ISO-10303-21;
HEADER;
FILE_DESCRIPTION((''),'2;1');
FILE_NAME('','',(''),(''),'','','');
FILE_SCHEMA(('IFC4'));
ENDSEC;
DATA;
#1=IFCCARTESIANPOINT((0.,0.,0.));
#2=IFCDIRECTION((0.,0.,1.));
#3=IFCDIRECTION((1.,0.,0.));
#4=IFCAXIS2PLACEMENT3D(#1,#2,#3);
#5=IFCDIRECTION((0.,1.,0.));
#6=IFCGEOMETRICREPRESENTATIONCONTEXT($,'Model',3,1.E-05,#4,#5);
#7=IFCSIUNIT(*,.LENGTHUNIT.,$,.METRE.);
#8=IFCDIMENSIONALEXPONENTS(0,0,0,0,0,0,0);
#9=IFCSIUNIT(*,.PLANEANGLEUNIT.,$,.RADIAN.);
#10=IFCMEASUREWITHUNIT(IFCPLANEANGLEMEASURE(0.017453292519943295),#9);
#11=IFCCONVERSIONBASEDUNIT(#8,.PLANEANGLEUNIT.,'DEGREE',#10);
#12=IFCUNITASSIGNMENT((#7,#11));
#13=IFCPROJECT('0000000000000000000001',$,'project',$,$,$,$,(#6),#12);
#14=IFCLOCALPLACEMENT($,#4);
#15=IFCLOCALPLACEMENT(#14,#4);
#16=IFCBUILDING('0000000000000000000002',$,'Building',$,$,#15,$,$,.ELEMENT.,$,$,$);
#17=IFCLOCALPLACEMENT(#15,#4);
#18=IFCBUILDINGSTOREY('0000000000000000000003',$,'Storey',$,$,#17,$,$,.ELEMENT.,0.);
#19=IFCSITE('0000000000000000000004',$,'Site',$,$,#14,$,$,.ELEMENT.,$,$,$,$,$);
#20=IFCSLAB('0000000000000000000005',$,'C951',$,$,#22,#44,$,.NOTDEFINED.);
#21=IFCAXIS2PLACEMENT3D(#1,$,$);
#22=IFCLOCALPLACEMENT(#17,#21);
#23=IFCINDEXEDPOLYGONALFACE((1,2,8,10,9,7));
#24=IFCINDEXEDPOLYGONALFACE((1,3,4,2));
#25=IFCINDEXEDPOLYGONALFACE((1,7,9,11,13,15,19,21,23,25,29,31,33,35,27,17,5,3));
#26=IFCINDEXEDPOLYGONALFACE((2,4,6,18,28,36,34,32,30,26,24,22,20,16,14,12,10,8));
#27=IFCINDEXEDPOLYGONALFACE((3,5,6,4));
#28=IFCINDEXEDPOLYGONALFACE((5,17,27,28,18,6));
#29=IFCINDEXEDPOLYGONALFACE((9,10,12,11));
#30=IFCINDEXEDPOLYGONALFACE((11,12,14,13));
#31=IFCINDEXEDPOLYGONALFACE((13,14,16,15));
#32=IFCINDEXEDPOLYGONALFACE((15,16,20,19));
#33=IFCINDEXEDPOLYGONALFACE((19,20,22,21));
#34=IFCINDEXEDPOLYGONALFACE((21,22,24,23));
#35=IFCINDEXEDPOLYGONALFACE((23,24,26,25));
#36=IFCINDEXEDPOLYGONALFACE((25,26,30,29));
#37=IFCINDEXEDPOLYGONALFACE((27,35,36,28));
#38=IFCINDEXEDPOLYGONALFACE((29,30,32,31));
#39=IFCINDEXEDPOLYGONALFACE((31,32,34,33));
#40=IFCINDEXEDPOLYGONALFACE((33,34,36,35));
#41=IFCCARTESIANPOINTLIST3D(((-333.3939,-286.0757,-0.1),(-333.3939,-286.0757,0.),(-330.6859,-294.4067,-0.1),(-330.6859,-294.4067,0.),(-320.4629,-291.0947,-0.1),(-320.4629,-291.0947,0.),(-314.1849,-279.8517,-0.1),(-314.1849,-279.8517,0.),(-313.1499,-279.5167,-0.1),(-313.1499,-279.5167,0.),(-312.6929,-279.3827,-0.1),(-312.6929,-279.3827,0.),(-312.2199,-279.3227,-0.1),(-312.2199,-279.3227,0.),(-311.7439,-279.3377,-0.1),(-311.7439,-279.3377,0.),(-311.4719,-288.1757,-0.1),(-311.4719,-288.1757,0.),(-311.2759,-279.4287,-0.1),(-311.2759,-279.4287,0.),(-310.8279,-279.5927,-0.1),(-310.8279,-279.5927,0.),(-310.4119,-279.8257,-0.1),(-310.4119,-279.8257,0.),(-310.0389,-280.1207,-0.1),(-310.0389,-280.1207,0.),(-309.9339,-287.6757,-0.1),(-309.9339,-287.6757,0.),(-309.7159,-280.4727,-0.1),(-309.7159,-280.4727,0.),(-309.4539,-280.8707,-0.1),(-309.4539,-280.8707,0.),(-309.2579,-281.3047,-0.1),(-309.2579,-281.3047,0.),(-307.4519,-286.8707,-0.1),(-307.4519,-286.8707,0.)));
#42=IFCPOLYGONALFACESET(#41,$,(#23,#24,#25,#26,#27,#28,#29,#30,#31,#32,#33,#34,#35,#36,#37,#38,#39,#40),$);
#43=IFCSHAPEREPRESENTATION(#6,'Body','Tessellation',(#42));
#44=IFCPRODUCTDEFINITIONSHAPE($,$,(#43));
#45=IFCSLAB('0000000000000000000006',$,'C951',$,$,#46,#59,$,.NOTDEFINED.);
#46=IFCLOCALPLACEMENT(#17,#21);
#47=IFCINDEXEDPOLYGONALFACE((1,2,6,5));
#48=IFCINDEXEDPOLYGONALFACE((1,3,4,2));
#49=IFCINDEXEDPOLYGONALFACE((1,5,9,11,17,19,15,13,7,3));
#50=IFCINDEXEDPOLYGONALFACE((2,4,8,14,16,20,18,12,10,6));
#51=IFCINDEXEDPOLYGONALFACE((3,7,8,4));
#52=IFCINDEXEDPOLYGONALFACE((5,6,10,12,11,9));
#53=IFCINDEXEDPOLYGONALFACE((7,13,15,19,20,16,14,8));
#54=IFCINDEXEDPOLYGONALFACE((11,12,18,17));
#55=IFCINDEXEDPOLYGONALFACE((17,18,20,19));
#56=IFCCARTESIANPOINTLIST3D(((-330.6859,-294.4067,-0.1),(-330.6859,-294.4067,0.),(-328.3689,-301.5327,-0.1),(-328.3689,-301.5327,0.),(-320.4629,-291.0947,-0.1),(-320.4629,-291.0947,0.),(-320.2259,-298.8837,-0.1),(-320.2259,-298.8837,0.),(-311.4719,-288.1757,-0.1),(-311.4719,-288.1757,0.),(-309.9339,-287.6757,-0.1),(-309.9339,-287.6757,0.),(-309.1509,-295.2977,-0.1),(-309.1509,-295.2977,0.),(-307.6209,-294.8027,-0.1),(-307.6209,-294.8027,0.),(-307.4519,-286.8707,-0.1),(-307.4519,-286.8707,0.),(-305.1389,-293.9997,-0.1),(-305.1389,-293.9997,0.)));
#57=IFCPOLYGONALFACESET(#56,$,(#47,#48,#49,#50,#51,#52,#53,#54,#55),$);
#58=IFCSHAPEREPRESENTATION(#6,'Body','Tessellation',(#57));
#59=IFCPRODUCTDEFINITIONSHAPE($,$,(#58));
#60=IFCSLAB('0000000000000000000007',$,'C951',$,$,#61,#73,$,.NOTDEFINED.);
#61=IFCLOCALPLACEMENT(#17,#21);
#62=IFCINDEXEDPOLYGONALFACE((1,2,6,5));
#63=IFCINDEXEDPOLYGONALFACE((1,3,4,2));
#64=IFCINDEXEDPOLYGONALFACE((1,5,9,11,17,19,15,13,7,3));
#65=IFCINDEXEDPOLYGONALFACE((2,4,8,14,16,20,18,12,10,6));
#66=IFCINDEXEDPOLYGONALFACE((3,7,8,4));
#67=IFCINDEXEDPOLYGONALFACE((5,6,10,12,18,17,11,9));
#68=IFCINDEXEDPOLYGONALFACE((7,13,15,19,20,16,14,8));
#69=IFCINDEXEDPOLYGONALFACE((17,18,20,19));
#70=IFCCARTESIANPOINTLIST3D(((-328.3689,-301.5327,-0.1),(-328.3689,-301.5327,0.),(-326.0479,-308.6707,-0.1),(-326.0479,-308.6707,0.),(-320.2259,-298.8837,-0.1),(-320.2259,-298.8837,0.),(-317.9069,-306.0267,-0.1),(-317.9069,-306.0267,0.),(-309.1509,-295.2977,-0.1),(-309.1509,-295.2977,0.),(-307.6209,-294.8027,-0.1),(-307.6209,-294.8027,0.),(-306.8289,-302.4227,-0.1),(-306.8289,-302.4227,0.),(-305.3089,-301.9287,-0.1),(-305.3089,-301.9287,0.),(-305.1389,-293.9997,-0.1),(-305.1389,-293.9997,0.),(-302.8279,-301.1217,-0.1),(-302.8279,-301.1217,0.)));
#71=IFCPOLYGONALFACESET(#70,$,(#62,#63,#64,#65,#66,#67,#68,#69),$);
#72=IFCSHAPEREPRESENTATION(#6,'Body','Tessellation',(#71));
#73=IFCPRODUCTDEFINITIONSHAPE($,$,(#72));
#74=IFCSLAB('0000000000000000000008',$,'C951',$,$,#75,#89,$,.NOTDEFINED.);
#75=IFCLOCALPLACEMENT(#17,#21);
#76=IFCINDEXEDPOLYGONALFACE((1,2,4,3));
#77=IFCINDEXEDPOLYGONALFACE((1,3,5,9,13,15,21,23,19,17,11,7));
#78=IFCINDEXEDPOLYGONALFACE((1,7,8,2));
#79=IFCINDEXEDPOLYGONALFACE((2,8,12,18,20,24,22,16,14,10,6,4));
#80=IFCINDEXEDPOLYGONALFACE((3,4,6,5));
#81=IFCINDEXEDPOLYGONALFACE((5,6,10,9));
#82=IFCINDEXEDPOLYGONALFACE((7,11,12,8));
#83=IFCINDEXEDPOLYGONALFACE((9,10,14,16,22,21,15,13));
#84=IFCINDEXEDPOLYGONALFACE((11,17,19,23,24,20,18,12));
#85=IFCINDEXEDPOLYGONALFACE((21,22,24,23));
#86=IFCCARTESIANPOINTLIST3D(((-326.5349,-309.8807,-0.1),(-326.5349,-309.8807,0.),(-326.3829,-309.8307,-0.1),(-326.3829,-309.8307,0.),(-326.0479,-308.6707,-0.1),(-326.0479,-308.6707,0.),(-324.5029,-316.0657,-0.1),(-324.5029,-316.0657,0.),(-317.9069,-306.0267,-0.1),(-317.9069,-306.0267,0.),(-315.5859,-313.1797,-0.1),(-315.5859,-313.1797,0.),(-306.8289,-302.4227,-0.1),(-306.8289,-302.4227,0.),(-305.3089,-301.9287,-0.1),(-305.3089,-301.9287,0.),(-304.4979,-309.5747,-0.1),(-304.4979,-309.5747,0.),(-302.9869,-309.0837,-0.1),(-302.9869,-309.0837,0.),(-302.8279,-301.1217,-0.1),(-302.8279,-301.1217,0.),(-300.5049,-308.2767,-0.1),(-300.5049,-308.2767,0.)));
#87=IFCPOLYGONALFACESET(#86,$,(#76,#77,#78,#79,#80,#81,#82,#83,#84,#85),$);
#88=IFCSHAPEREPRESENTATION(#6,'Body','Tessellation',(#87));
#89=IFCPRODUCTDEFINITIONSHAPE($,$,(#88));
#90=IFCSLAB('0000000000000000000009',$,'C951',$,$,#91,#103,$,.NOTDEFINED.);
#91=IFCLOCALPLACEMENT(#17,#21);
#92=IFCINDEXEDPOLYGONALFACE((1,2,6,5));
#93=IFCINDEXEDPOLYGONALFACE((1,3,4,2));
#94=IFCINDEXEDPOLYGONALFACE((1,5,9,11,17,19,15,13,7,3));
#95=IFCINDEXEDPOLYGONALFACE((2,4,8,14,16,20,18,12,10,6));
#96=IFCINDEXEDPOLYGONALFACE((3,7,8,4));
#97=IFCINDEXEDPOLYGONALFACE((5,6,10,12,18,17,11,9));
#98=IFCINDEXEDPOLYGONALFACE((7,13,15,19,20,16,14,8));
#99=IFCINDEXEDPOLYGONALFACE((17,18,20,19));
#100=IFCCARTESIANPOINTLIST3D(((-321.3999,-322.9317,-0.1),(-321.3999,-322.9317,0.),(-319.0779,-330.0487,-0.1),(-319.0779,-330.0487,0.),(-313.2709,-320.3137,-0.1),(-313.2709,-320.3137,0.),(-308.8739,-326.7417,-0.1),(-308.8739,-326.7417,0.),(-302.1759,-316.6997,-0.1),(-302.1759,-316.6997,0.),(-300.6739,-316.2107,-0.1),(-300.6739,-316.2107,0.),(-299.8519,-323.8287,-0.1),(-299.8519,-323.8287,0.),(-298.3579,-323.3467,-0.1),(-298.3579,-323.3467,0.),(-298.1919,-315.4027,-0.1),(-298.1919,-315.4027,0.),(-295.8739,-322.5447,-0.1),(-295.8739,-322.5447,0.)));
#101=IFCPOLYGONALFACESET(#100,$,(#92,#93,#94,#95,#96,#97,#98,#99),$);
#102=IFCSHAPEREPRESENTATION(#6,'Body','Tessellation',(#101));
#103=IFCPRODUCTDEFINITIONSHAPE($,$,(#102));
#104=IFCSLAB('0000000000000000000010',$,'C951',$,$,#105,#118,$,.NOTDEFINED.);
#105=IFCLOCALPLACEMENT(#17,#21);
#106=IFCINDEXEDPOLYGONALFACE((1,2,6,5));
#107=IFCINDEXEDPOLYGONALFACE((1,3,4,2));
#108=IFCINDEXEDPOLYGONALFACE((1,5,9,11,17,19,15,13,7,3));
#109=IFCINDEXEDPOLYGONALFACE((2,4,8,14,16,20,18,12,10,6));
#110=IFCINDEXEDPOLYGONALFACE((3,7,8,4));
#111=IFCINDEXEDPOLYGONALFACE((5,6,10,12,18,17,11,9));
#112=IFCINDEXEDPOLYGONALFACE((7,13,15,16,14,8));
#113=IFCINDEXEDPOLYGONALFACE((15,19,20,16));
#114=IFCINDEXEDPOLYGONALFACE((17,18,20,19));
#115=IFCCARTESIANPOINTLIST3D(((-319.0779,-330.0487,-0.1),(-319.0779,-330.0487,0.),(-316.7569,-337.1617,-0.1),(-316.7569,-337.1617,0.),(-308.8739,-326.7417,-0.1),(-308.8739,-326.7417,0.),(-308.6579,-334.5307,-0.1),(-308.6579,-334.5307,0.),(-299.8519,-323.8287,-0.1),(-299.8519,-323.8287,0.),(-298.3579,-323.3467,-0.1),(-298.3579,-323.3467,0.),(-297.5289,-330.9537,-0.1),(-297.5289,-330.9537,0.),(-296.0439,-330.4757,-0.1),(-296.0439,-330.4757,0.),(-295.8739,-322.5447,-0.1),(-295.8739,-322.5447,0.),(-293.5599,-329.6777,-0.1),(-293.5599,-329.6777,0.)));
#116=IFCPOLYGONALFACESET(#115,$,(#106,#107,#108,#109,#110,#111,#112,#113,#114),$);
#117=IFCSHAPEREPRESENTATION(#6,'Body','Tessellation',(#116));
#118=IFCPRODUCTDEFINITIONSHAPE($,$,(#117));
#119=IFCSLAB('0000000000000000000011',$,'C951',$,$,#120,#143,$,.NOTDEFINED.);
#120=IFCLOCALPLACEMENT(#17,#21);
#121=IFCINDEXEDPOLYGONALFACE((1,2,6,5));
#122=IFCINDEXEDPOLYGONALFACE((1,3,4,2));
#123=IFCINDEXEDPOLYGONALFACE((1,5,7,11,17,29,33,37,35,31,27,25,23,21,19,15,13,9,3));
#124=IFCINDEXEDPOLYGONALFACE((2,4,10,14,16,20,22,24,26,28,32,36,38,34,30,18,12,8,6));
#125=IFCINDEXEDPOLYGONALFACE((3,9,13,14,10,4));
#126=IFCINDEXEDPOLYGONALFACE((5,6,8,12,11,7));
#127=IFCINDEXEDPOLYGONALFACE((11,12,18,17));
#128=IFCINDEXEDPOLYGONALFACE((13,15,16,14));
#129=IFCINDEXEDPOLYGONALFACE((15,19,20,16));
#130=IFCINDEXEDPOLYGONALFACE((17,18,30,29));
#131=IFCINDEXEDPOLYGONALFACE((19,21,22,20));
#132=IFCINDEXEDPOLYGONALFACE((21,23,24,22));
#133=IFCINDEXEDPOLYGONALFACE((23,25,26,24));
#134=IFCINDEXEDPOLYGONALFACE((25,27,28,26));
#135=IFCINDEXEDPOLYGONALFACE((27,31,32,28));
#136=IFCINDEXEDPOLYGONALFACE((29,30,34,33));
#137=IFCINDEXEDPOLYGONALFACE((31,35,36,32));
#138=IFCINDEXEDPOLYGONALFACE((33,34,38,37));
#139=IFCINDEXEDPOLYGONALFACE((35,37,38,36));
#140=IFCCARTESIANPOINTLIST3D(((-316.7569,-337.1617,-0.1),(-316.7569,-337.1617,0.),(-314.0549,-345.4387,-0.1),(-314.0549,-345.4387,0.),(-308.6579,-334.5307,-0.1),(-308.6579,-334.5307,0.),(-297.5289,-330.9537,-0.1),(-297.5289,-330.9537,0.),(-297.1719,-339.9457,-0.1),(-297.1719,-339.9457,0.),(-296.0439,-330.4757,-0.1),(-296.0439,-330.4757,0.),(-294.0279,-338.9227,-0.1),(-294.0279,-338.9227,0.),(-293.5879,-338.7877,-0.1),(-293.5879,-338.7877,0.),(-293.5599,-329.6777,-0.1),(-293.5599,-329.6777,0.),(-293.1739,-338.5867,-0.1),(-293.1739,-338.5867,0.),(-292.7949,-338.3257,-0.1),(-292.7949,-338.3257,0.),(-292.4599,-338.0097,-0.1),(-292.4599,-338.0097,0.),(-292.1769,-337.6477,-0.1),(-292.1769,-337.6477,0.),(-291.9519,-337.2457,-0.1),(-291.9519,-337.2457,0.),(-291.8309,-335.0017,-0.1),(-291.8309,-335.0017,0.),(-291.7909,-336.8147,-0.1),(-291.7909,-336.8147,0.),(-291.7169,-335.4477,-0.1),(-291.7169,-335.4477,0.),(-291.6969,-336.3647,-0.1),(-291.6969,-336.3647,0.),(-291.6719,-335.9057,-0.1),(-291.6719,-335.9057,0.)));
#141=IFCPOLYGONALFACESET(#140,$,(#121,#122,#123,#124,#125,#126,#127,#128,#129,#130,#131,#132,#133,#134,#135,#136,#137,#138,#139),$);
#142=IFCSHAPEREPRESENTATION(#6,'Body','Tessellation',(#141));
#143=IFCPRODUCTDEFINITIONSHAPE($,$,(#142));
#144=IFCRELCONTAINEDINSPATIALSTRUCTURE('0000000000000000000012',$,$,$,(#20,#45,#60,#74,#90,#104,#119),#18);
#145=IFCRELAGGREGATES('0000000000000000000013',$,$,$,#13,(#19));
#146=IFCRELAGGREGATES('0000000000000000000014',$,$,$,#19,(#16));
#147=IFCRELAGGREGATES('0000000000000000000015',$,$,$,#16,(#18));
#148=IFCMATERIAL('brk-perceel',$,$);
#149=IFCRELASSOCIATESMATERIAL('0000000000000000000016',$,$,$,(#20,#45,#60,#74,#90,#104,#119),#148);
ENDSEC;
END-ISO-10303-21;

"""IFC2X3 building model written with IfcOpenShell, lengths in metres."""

from ifc_helpers import new_model, entity, si_unit, converted_unit, direction, frame, origin_with_axes, place, context, project, spatial, polyline, outline, extrude, material, element, save


model = new_model("IFC2X3")

# Units and contexts
model_context = context("Model", 3, precision=1e-05, world=origin_with_axes(), true_north=direction((0.0, 1.0, 0.0)))
ifc_project = project(units=[si_unit("LENGTHUNIT", "METRE"), converted_unit("PLANEANGLEUNIT", "DEGREE", entity("IfcPlaneAngleMeasure", 0.017453292519943295), si_unit("PLANEANGLEUNIT", "RADIAN"), dimensions=[0, 0, 0, 0, 0, 0, 0])], contexts=[model_context])

# Site, building, storey
site_placement = place(None, origin_with_axes())
site = spatial("IfcSite", under=ifc_project, at=site_placement, Name="Site", CompositionType="ELEMENT")
building_placement = place(site_placement, origin_with_axes())
building = spatial("IfcBuilding", under=site, at=building_placement, Name="Building", CompositionType="ELEMENT")
storey_placement = place(building_placement, origin_with_axes())
storey = spatial("IfcBuildingStorey", under=building, at=storey_placement, Name="Storey", CompositionType="ELEMENT", Elevation=0.0)

# Slabs
ifc_material = material(Name="brk-perceel")
slab_1_placement = place(storey_placement, frame((0.0, 0.0, -0.1), z_axis=(0.0, 0.0, 1.0), x_axis=(1.0, 0.0, 0.0)))
element("IfcSlab", 1, at=slab_1_placement, inside=storey, material=ifc_material, Name="C951", PredefinedType="NOTDEFINED", context=model_context, shape_type="SweptSolid", body=[
    extrude(outline(polyline([(-312.6929, -279.3827), (-312.2199, -279.3227), (-311.7439, -279.3377), (-311.2759, -279.4287), (-310.8279, -279.5927), (-310.4119, -279.8257), (-310.0389, -280.1207), (-309.7159, -280.4727), (-309.4539, -280.8707), (-309.2579, -281.3047), (-307.4519, -286.8707), (-309.9339, -287.6757), (-311.4719, -288.1757), (-320.4629, -291.0947), (-330.6859, -294.4067), (-333.3939, -286.0757), (-314.1849, -279.8517), (-313.1499, -279.5167), (-312.6929, -279.3827)])), origin_with_axes(), (0.0, 0.0, 1.0), 0.1),
])
slab_2_placement = place(storey_placement, frame((0.0, 0.0, -0.1), z_axis=(0.0, 0.0, 1.0), x_axis=(1.0, 0.0, 0.0)))
element("IfcSlab", 2, at=slab_2_placement, inside=storey, material=ifc_material, Name="C951", PredefinedType="NOTDEFINED", context=model_context, shape_type="SweptSolid", body=[
    extrude(outline(polyline([(-320.4629, -291.0947), (-311.4719, -288.1757), (-309.9339, -287.6757), (-307.4519, -286.8707), (-305.1389, -293.9997), (-307.6209, -294.8027), (-309.1509, -295.2977), (-320.2259, -298.8837), (-328.3689, -301.5327), (-330.6859, -294.4067), (-320.4629, -291.0947)])), origin_with_axes(), (0.0, 0.0, 1.0), 0.1),
])
slab_3_placement = place(storey_placement, frame((0.0, 0.0, -0.1), z_axis=(0.0, 0.0, 1.0), x_axis=(1.0, 0.0, 0.0)))
element("IfcSlab", 3, at=slab_3_placement, inside=storey, material=ifc_material, Name="C951", PredefinedType="NOTDEFINED", context=model_context, shape_type="SweptSolid", body=[
    extrude(outline(polyline([(-320.2259, -298.8837), (-309.1509, -295.2977), (-307.6209, -294.8027), (-305.1389, -293.9997), (-302.8279, -301.1217), (-305.3089, -301.9287), (-306.8289, -302.4227), (-317.9069, -306.0267), (-326.0479, -308.6707), (-328.3689, -301.5327), (-320.2259, -298.8837)])), origin_with_axes(), (0.0, 0.0, 1.0), 0.1),
])
slab_4_placement = place(storey_placement, frame((0.0, 0.0, -0.1), z_axis=(0.0, 0.0, 1.0), x_axis=(1.0, 0.0, 0.0)))
element("IfcSlab", 4, at=slab_4_placement, inside=storey, material=ifc_material, Name="C951", PredefinedType="NOTDEFINED", context=model_context, shape_type="SweptSolid", body=[
    extrude(outline(polyline([(-326.5349, -309.8807), (-326.3829, -309.8307), (-326.0479, -308.6707), (-317.9069, -306.0267), (-306.8289, -302.4227), (-305.3089, -301.9287), (-302.8279, -301.1217), (-300.5049, -308.2767), (-302.9869, -309.0837), (-304.4979, -309.5747), (-315.5859, -313.1797), (-324.5029, -316.0657), (-326.5349, -309.8807)])), origin_with_axes(), (0.0, 0.0, 1.0), 0.1),
])
slab_5_placement = place(storey_placement, frame((0.0, 0.0, -0.1), z_axis=(0.0, 0.0, 1.0), x_axis=(1.0, 0.0, 0.0)))
element("IfcSlab", 5, at=slab_5_placement, inside=storey, material=ifc_material, Name="C951", PredefinedType="NOTDEFINED", context=model_context, shape_type="SweptSolid", body=[
    extrude(outline(polyline([(-321.3999, -322.9317), (-313.2709, -320.3137), (-302.1759, -316.6997), (-300.6739, -316.2107), (-298.1919, -315.4027), (-295.8739, -322.5447), (-298.3579, -323.3467), (-299.8519, -323.8287), (-308.8739, -326.7417), (-319.0779, -330.0487), (-321.3999, -322.9317)])), origin_with_axes(), (0.0, 0.0, 1.0), 0.1),
])
slab_6_placement = place(storey_placement, frame((0.0, 0.0, -0.1), z_axis=(0.0, 0.0, 1.0), x_axis=(1.0, 0.0, 0.0)))
element("IfcSlab", 6, at=slab_6_placement, inside=storey, material=ifc_material, Name="C951", PredefinedType="NOTDEFINED", context=model_context, shape_type="SweptSolid", body=[
    extrude(outline(polyline([(-308.8739, -326.7417), (-299.8519, -323.8287), (-298.3579, -323.3467), (-295.8739, -322.5447), (-293.5599, -329.6777), (-296.0439, -330.4757), (-297.5289, -330.9537), (-308.6579, -334.5307), (-316.7569, -337.1617), (-319.0779, -330.0487), (-308.8739, -326.7417)])), origin_with_axes(), (0.0, 0.0, 1.0), 0.1),
])
slab_7_placement = place(storey_placement, frame((0.0, 0.0, -0.1), z_axis=(0.0, 0.0, 1.0), x_axis=(1.0, 0.0, 0.0)))
element("IfcSlab", 7, at=slab_7_placement, inside=storey, material=ifc_material, Name="C951", PredefinedType="NOTDEFINED", context=model_context, shape_type="SweptSolid", body=[
    extrude(outline(polyline([(-308.6579, -334.5307), (-297.5289, -330.9537), (-296.0439, -330.4757), (-293.5599, -329.6777), (-291.8309, -335.0017), (-291.7169, -335.4477), (-291.6719, -335.9057), (-291.6969, -336.3647), (-291.7909, -336.8147), (-291.9519, -337.2457), (-292.1769, -337.6477), (-292.4599, -338.0097), (-292.7949, -338.3257), (-293.1739, -338.5867), (-293.5879, -338.7877), (-294.0279, -338.9227), (-297.1719, -339.9457), (-314.0549, -345.4387), (-316.7569, -337.1617), (-308.6579, -334.5307)])), origin_with_axes(), (0.0, 0.0, 1.0), 0.1),
])

save(model, "model.ifc")
